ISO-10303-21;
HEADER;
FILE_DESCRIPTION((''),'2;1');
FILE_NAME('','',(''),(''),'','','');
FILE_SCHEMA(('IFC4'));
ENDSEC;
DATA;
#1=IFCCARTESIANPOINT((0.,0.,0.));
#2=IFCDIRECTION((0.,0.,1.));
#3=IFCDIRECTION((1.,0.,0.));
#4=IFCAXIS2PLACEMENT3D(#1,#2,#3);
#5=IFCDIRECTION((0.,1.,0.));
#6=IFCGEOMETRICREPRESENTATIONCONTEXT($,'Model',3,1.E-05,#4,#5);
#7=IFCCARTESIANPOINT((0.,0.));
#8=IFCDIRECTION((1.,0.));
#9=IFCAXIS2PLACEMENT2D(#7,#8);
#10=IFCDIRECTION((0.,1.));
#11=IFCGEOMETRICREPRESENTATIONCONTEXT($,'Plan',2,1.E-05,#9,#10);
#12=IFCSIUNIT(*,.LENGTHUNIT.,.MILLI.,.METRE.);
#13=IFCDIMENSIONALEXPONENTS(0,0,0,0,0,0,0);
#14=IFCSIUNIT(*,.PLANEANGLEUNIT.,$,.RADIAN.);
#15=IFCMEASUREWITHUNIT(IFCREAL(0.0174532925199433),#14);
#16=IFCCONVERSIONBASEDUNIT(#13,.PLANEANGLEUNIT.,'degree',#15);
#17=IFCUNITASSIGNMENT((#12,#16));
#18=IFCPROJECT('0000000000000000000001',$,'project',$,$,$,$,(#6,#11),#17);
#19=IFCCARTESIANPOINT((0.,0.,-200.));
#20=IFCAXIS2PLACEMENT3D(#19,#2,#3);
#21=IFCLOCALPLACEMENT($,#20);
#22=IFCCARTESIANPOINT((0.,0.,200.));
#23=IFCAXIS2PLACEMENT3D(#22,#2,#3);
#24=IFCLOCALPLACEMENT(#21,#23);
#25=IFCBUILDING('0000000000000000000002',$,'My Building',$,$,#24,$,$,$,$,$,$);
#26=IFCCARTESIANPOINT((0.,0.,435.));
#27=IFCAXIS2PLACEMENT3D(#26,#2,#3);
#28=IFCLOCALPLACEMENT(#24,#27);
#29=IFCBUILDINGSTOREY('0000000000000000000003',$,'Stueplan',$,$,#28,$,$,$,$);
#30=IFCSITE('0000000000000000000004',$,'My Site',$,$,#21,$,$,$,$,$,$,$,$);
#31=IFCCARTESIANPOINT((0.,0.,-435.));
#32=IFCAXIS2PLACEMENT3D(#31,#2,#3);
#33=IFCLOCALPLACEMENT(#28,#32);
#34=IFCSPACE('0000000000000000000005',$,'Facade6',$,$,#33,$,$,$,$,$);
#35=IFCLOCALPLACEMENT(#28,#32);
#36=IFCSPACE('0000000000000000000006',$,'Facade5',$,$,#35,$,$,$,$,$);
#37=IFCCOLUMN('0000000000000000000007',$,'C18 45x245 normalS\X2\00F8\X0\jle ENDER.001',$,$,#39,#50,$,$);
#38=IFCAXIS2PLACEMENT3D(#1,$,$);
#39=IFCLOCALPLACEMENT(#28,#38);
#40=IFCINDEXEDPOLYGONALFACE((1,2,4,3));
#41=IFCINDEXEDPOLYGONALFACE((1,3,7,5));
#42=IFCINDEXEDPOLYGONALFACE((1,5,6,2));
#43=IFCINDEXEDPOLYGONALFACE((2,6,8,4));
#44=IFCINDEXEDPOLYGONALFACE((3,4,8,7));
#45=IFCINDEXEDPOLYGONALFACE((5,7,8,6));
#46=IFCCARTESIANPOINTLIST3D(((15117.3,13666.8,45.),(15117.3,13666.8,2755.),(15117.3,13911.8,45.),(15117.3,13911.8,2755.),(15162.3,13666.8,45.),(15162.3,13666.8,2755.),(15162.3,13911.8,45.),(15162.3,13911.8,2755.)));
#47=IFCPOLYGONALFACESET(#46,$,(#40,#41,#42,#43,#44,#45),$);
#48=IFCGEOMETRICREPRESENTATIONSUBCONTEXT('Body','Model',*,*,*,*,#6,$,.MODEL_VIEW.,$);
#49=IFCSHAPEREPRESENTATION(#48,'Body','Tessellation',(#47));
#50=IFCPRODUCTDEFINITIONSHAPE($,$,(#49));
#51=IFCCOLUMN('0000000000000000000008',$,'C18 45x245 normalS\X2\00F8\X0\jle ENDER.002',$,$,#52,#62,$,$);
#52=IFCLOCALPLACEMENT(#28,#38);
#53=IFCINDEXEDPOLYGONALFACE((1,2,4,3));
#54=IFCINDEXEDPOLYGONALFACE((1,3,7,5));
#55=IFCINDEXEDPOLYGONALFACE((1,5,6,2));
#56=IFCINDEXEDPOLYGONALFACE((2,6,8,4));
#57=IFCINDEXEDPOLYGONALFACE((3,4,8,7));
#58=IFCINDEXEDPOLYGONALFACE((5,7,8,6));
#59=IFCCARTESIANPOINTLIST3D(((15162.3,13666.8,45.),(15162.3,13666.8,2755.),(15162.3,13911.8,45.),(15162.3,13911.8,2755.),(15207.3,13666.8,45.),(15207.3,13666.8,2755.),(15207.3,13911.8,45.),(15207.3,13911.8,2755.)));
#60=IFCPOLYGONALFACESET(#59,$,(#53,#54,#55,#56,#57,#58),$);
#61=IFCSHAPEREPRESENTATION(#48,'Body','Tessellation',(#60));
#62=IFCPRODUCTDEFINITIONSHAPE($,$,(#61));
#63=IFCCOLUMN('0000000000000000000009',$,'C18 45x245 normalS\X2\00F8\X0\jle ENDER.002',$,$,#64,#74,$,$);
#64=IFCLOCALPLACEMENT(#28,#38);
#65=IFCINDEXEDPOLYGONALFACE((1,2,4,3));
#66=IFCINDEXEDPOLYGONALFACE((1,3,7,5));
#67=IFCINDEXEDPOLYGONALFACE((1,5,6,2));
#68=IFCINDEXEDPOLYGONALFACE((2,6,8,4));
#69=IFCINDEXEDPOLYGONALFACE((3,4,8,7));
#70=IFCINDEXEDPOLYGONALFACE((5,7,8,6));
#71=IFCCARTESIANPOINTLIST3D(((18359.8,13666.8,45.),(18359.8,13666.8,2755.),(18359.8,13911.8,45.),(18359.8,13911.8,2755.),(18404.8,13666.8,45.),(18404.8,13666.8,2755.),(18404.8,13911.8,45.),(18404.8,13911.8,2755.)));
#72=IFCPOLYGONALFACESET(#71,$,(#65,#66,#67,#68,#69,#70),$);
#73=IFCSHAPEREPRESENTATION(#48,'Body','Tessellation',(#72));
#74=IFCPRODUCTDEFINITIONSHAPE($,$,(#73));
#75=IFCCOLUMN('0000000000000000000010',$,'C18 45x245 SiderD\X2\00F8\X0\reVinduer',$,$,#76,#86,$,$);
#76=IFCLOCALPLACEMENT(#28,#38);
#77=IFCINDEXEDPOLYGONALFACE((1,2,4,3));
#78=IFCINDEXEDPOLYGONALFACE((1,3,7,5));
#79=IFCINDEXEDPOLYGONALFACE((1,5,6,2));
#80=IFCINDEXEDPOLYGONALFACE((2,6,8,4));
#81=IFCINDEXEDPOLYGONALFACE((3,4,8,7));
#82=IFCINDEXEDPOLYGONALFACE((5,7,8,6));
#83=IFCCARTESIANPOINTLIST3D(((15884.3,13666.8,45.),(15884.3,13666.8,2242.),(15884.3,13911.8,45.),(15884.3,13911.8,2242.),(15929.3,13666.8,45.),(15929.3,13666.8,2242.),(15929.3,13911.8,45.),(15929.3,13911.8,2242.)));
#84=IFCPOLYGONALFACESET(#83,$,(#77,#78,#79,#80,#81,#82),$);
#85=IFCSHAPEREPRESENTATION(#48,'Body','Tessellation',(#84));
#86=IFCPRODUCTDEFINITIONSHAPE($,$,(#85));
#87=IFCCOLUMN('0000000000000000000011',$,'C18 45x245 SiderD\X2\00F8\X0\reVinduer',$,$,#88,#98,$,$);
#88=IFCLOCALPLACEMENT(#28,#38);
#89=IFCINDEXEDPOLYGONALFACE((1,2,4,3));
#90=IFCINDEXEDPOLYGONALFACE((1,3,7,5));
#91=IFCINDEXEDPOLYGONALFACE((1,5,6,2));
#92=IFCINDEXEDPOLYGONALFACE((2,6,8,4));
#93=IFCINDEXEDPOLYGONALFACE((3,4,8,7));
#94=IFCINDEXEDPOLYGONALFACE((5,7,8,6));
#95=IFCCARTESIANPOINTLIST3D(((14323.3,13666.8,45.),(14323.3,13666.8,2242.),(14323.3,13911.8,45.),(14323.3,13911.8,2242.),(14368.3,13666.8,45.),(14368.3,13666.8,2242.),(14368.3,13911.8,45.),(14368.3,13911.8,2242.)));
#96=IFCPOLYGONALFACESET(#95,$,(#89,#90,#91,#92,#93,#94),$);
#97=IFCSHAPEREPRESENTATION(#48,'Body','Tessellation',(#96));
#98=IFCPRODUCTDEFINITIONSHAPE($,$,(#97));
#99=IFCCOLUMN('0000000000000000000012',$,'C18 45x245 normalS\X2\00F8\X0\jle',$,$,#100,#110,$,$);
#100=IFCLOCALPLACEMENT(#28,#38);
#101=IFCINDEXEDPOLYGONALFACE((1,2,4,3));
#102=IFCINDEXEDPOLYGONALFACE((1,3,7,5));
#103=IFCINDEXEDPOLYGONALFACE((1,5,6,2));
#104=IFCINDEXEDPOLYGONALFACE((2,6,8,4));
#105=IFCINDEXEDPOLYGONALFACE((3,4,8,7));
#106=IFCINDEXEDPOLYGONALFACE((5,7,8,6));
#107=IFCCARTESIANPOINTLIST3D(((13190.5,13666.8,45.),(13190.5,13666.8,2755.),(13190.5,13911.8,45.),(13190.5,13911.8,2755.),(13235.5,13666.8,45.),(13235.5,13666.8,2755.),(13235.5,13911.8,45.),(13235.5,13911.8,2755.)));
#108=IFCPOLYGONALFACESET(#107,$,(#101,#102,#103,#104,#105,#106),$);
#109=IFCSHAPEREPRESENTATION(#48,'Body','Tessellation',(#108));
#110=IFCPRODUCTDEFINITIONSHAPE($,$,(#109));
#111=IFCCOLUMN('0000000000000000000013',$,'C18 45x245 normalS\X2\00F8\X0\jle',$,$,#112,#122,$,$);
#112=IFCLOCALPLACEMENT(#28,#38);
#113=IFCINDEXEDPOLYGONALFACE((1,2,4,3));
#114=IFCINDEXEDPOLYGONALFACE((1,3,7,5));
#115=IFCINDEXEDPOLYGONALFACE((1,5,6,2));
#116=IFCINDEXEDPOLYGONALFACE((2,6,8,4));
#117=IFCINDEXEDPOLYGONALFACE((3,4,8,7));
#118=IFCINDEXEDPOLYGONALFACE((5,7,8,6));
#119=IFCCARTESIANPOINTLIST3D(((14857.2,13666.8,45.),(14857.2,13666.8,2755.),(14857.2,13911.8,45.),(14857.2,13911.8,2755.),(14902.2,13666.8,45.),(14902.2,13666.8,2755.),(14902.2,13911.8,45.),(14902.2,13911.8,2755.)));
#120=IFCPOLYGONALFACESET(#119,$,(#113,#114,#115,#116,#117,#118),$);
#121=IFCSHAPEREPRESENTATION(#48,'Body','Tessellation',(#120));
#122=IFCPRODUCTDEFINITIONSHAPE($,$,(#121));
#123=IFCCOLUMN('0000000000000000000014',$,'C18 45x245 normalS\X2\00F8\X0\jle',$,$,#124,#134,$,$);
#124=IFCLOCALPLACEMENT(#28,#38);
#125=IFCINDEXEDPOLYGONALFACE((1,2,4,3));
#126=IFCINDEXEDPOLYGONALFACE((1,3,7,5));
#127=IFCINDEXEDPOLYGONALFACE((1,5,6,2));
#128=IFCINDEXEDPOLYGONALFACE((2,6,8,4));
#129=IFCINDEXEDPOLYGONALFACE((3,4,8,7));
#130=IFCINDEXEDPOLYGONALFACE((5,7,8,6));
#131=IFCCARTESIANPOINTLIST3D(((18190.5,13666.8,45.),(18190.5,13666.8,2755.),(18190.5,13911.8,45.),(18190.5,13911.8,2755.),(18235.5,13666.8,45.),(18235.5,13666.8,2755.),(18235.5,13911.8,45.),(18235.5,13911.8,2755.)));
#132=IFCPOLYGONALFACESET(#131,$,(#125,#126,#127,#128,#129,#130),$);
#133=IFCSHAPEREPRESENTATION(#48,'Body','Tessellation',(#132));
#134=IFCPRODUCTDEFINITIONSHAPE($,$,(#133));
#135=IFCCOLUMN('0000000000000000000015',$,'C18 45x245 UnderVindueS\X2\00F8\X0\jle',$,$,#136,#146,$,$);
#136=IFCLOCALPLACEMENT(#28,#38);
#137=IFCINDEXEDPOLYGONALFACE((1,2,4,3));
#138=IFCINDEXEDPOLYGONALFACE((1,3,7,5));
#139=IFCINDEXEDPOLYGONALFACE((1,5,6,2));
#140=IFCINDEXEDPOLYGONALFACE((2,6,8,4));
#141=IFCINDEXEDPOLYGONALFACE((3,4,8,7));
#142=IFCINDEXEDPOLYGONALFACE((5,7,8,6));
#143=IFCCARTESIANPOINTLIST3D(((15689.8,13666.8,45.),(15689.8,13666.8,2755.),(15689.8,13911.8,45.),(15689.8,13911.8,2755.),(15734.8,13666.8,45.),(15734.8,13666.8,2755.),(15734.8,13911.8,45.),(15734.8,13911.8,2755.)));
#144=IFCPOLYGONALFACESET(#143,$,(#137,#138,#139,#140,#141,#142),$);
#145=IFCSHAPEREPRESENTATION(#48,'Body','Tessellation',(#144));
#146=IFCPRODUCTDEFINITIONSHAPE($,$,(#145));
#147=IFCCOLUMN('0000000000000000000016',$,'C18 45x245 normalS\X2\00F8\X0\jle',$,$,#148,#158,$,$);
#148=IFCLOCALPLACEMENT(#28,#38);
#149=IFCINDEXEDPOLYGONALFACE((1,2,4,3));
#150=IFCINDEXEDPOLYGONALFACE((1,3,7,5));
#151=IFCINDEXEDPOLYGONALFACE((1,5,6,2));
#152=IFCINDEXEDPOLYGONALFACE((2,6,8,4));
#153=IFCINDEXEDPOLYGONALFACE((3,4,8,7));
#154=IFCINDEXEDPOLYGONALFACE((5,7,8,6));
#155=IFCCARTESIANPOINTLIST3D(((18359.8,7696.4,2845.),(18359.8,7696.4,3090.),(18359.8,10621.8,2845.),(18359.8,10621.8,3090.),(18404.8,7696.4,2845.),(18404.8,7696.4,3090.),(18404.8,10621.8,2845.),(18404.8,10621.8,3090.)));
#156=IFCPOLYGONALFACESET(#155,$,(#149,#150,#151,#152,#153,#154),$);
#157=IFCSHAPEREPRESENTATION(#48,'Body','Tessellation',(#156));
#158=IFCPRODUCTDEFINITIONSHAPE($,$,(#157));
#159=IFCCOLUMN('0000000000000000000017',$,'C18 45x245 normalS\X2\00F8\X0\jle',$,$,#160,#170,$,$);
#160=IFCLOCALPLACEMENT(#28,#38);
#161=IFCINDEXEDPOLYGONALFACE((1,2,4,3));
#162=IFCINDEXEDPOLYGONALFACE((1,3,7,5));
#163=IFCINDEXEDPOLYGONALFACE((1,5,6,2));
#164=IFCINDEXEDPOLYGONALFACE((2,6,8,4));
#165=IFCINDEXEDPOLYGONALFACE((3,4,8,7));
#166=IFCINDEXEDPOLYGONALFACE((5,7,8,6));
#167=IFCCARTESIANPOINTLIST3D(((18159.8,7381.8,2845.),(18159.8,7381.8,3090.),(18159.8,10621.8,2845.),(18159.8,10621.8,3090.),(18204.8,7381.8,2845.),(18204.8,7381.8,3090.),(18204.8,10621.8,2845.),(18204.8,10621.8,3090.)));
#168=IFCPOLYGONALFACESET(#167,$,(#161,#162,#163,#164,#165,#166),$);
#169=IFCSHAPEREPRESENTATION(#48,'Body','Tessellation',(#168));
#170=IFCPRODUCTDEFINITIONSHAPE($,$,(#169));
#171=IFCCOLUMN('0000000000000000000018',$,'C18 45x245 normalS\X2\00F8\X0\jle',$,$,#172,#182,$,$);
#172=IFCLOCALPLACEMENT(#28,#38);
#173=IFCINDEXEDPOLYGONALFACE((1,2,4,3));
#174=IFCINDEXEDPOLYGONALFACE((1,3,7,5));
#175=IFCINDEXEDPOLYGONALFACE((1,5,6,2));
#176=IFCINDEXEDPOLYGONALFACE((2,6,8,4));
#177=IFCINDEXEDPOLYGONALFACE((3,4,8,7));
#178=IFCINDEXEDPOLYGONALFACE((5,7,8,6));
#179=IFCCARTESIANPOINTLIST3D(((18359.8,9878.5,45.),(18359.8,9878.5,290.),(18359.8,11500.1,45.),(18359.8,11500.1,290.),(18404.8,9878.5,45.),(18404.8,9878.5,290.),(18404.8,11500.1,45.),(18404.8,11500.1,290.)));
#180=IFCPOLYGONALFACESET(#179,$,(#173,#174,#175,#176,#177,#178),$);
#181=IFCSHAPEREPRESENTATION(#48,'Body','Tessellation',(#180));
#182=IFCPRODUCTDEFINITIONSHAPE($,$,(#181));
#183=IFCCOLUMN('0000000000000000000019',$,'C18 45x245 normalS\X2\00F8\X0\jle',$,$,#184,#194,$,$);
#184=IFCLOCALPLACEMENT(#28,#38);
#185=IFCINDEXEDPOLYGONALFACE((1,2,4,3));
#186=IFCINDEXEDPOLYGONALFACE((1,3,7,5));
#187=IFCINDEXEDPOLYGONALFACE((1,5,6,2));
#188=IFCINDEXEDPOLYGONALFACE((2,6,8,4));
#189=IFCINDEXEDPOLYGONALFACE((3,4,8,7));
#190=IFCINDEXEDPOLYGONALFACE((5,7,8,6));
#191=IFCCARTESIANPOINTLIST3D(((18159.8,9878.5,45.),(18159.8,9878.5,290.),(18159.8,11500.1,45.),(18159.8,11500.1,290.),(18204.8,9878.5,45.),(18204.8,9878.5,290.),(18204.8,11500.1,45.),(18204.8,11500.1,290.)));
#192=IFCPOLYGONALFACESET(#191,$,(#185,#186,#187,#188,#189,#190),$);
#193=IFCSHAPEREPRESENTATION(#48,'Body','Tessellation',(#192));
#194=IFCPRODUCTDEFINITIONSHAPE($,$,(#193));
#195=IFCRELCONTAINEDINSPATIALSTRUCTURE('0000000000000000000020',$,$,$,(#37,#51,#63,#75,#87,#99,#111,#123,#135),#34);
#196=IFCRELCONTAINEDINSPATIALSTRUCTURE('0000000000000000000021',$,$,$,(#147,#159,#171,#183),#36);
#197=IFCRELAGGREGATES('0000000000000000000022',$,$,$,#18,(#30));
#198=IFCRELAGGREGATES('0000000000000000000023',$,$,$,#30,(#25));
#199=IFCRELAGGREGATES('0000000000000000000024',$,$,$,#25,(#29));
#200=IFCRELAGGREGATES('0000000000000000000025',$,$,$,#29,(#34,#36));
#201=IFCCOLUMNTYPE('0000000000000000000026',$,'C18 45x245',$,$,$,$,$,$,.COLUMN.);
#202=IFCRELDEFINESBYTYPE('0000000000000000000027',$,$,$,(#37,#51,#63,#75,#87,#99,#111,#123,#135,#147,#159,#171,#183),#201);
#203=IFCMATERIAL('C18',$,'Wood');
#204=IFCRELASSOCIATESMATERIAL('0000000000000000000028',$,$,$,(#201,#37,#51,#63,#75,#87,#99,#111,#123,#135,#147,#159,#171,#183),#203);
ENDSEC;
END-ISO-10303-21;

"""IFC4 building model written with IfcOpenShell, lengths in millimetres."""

from ifc_helpers import new_model, entity, si_unit, converted_unit, direction, frame, origin_with_axes, origin_2d_with_axis, place, context, subcontext, project, spatial, rectangle, extrude, material, material_profile, profile_set, profile_usage, type_object, element, save


model = new_model("IFC4")

# Units and contexts
model_context = context("Model", 3, precision=1e-05, world=origin_with_axes(), true_north=direction((0.0, 1.0, 0.0)))
plan_context = context("Plan", 2, precision=1e-05, world=origin_2d_with_axis(), true_north=direction((0.0, 1.0)))
body_context_1 = subcontext(model_context, "Body", "Model", "MODEL_VIEW")
ifc_project = project(units=[si_unit("LENGTHUNIT", "METRE", prefix="MILLI"), converted_unit("PLANEANGLEUNIT", "degree", entity("IfcReal", 0.0174532925199433), si_unit("PLANEANGLEUNIT", "RADIAN"), dimensions=[0, 0, 0, 0, 0, 0, 0])], contexts=[model_context, plan_context])

# Site, building, storey, space
site_placement = place(None, frame((0.0, 0.0, -200.0), z_axis=(0.0, 0.0, 1.0), x_axis=(1.0, 0.0, 0.0)))
site = spatial("IfcSite", under=ifc_project, at=site_placement, Name="My Site")
building_placement = place(site_placement, frame((0.0, 0.0, 200.0), z_axis=(0.0, 0.0, 1.0), x_axis=(1.0, 0.0, 0.0)))
building = spatial("IfcBuilding", under=site, at=building_placement, Name="My Building")
storey_placement = place(building_placement, frame((0.0, 0.0, 435.0), z_axis=(0.0, 0.0, 1.0), x_axis=(1.0, 0.0, 0.0)))
storey = spatial("IfcBuildingStorey", under=building, at=storey_placement, Name="Stueplan")
space_1_placement = place(storey_placement, frame((0.0, 0.0, -435.0), z_axis=(0.0, 0.0, 1.0), x_axis=(1.0, 0.0, 0.0)))
space_1 = spatial("IfcSpace", under=storey, at=space_1_placement, Name="Facade6")

# Columns
ifc_material = material(Name="C18", Category="Wood")
ifc_material_profile_1 = material_profile(ifc_material, rectangle(XDim=45.0, YDim=245.0))
ifc_profile_set_1 = profile_set([ifc_material_profile_1], Name="woodStructural")
ifc_profile_usage_1 = profile_usage(ifc_profile_set_1, cardinal=9)
column_type = type_object("IfcColumnType", Name="C18 45x245", PredefinedType="COLUMN", material=ifc_profile_set_1)
column_1_placement = place(space_1_placement, frame((15117.3, 13911.8, 480.0), z_axis=(0.0, 0.0, 1.0), x_axis=(1.0, 0.0, 0.0)))
element("IfcColumn", 1, at=column_1_placement, inside=space_1, type_object=column_type, material=ifc_profile_usage_1, Name="C18 45x245 normalSøjle ENDER.001", context=body_context_1, shape_type="SweptSolid", body=[
    extrude(rectangle(XDim=45.0, YDim=245.0), frame((22.5, -122.5, 0.0), z_axis=(0.0, 0.0, 1.0), x_axis=(1.0, 0.0, 0.0)), (0.0, 0.0, 1.0), 2710.0),
])
ifc_profile_usage_2 = profile_usage(ifc_profile_set_1, cardinal=9)
column_2_placement = place(space_1_placement, frame((15162.3, 13911.8, 480.0), z_axis=(0.0, 0.0, 1.0), x_axis=(1.0, 0.0, 0.0)))
element("IfcColumn", 2, at=column_2_placement, inside=space_1, type_object=column_type, material=ifc_profile_usage_2, Name="C18 45x245 normalSøjle ENDER.002", context=body_context_1, shape_type="SweptSolid", body=[
    extrude(rectangle(XDim=45.0, YDim=245.0), frame((22.5, -122.5, 0.0), z_axis=(0.0, 0.0, 1.0), x_axis=(1.0, 0.0, 0.0)), (0.0, 0.0, 1.0), 2710.0),
])
ifc_profile_usage_3 = profile_usage(ifc_profile_set_1, cardinal=9)
column_3_placement = place(space_1_placement, frame((18359.8, 13911.8, 480.0), z_axis=(0.0, 0.0, 1.0), x_axis=(1.0, 0.0, 0.0)))
element("IfcColumn", 3, at=column_3_placement, inside=space_1, type_object=column_type, material=ifc_profile_usage_3, Name="C18 45x245 normalSøjle ENDER.002", context=body_context_1, shape_type="SweptSolid", body=[
    extrude(rectangle(XDim=45.0, YDim=245.0), frame((22.5, -122.5, 0.0), z_axis=(0.0, 0.0, 1.0), x_axis=(1.0, 0.0, 0.0)), (0.0, 0.0, 1.0), 2710.0),
])
ifc_profile_usage_4 = profile_usage(ifc_profile_set_1, cardinal=9)
column_4_placement = place(space_1_placement, frame((15884.3, 13911.8, 480.0), z_axis=(0.0, 0.0, 1.0), x_axis=(1.0, 0.0, 0.0)))
element("IfcColumn", 4, at=column_4_placement, inside=space_1, type_object=column_type, material=ifc_profile_usage_4, Name="C18 45x245 SiderDøreVinduer", context=body_context_1, shape_type="SweptSolid", body=[
    extrude(rectangle(XDim=45.0, YDim=245.0), frame((22.5, -122.5, 0.0), z_axis=(0.0, 0.0, 1.0), x_axis=(1.0, 0.0, 0.0)), (0.0, 0.0, 1.0), 2197.0),
])
ifc_profile_usage_5 = profile_usage(ifc_profile_set_1, cardinal=9)
column_5_placement = place(space_1_placement, frame((14323.3, 13911.8, 480.0), z_axis=(0.0, 0.0, 1.0), x_axis=(1.0, 0.0, 0.0)))
element("IfcColumn", 5, at=column_5_placement, inside=space_1, type_object=column_type, material=ifc_profile_usage_5, Name="C18 45x245 SiderDøreVinduer", context=body_context_1, shape_type="SweptSolid", body=[
    extrude(rectangle(XDim=45.0, YDim=245.0), frame((22.5, -122.5, 0.0), z_axis=(0.0, 0.0, 1.0), x_axis=(1.0, 0.0, 0.0)), (0.0, 0.0, 1.0), 2197.0),
])
ifc_profile_usage_6 = profile_usage(ifc_profile_set_1, cardinal=9)
column_6_placement = place(space_1_placement, frame((13190.5, 13911.8, 480.0), z_axis=(0.0, 0.0, 1.0), x_axis=(1.0, 0.0, 0.0)))
element("IfcColumn", 6, at=column_6_placement, inside=space_1, type_object=column_type, material=ifc_profile_usage_6, Name="C18 45x245 normalSøjle", context=body_context_1, shape_type="SweptSolid", body=[
    extrude(rectangle(XDim=45.0, YDim=245.0), frame((22.5, -122.5, 0.0), z_axis=(0.0, 0.0, 1.0), x_axis=(1.0, 0.0, 0.0)), (0.0, 0.0, 1.0), 2710.0),
])
ifc_profile_usage_7 = profile_usage(ifc_profile_set_1, cardinal=9)
column_7_placement = place(space_1_placement, frame((14857.2, 13911.8, 480.0), z_axis=(0.0, 0.0, 1.0), x_axis=(1.0, 0.0, 0.0)))
element("IfcColumn", 7, at=column_7_placement, inside=space_1, type_object=column_type, material=ifc_profile_usage_7, Name="C18 45x245 normalSøjle", context=body_context_1, shape_type="SweptSolid", body=[
    extrude(rectangle(XDim=45.0, YDim=245.0), frame((22.5, -122.5, 0.0), z_axis=(0.0, 0.0, 1.0), x_axis=(1.0, 0.0, 0.0)), (0.0, 0.0, 1.0), 2710.0),
])
ifc_profile_usage_8 = profile_usage(ifc_profile_set_1, cardinal=9)
column_8_placement = place(space_1_placement, frame((18190.5, 13911.8, 480.0), z_axis=(0.0, 0.0, 1.0), x_axis=(1.0, 0.0, 0.0)))
element("IfcColumn", 8, at=column_8_placement, inside=space_1, type_object=column_type, material=ifc_profile_usage_8, Name="C18 45x245 normalSøjle", context=body_context_1, shape_type="SweptSolid", body=[
    extrude(rectangle(XDim=45.0, YDim=245.0), frame((22.5, -122.5, 0.0), z_axis=(0.0, 0.0, 1.0), x_axis=(1.0, 0.0, 0.0)), (0.0, 0.0, 1.0), 2710.0),
])
ifc_profile_usage_9 = profile_usage(ifc_profile_set_1, cardinal=9)
column_9_placement = place(space_1_placement, frame((15689.8, 13911.8, 480.0), z_axis=(0.0, 0.0, 1.0), x_axis=(1.0, 0.0, 0.0)))
element("IfcColumn", 9, at=column_9_placement, inside=space_1, type_object=column_type, material=ifc_profile_usage_9, Name="C18 45x245 UnderVindueSøjle", context=body_context_1, shape_type="SweptSolid", body=[
    extrude(rectangle(XDim=45.0, YDim=245.0), frame((22.5, -122.5, 0.0), z_axis=(0.0, 0.0, 1.0), x_axis=(1.0, 0.0, 0.0)), (0.0, 0.0, 1.0), 2710.0),
])

# Shared definitions
space_2_placement = place(storey_placement, frame((0.0, 0.0, -435.0), z_axis=(0.0, 0.0, 1.0), x_axis=(1.0, 0.0, 0.0)))
space_2 = spatial("IfcSpace", under=storey, at=space_2_placement, Name="Facade5")

# Columns
ifc_profile_usage_10 = profile_usage(ifc_profile_set_1, cardinal=9)
column_10_placement = place(space_2_placement, frame((18359.8, 10621.8, 3525.0), z_axis=(0.0, -1.0, 0.0), x_axis=(1.0, 0.0, 0.0)))
element("IfcColumn", 10, at=column_10_placement, inside=space_2, type_object=column_type, material=ifc_profile_usage_10, Name="C18 45x245 normalSøjle", context=body_context_1, shape_type="SweptSolid", body=[
    extrude(rectangle(XDim=45.0, YDim=245.0), frame((22.5, -122.5, 0.0), z_axis=(0.0, 0.0, 1.0), x_axis=(1.0, 0.0, 0.0)), (0.0, 0.0, 1.0), 2925.4),
])
ifc_profile_usage_11 = profile_usage(ifc_profile_set_1, cardinal=9)
column_11_placement = place(space_2_placement, frame((18159.8, 10621.8, 3525.0), z_axis=(0.0, -1.0, 0.0), x_axis=(1.0, 0.0, 0.0)))
element("IfcColumn", 11, at=column_11_placement, inside=space_2, type_object=column_type, material=ifc_profile_usage_11, Name="C18 45x245 normalSøjle", context=body_context_1, shape_type="SweptSolid", body=[
    extrude(rectangle(XDim=45.0, YDim=245.0), frame((22.5, -122.5, 0.0), z_axis=(0.0, 0.0, 1.0), x_axis=(1.0, 0.0, 0.0)), (0.0, 0.0, 1.0), 3240.0),
])
ifc_profile_usage_12 = profile_usage(ifc_profile_set_1, cardinal=9)
column_12_placement = place(space_2_placement, frame((18359.8, 11500.1, 725.0), z_axis=(0.0, -1.0, 0.0), x_axis=(1.0, 0.0, 0.0)))
element("IfcColumn", 12, at=column_12_placement, inside=space_2, type_object=column_type, material=ifc_profile_usage_12, Name="C18 45x245 normalSøjle", context=body_context_1, shape_type="SweptSolid", body=[
    extrude(rectangle(XDim=45.0, YDim=245.0), frame((22.5, -122.5, 0.0), z_axis=(0.0, 0.0, 1.0), x_axis=(1.0, 0.0, 0.0)), (0.0, 0.0, 1.0), 1621.7),
])
ifc_profile_usage_13 = profile_usage(ifc_profile_set_1, cardinal=9)
column_13_placement = place(space_2_placement, frame((18159.8, 11500.1, 725.0), z_axis=(0.0, -1.0, 0.0), x_axis=(1.0, 0.0, 0.0)))
element("IfcColumn", 13, at=column_13_placement, inside=space_2, type_object=column_type, material=ifc_profile_usage_13, Name="C18 45x245 normalSøjle", context=body_context_1, shape_type="SweptSolid", body=[
    extrude(rectangle(XDim=45.0, YDim=245.0), frame((22.5, -122.5, 0.0), z_axis=(0.0, 0.0, 1.0), x_axis=(1.0, 0.0, 0.0)), (0.0, 0.0, 1.0), 1621.7),
])

save(model, "model.ifc")
